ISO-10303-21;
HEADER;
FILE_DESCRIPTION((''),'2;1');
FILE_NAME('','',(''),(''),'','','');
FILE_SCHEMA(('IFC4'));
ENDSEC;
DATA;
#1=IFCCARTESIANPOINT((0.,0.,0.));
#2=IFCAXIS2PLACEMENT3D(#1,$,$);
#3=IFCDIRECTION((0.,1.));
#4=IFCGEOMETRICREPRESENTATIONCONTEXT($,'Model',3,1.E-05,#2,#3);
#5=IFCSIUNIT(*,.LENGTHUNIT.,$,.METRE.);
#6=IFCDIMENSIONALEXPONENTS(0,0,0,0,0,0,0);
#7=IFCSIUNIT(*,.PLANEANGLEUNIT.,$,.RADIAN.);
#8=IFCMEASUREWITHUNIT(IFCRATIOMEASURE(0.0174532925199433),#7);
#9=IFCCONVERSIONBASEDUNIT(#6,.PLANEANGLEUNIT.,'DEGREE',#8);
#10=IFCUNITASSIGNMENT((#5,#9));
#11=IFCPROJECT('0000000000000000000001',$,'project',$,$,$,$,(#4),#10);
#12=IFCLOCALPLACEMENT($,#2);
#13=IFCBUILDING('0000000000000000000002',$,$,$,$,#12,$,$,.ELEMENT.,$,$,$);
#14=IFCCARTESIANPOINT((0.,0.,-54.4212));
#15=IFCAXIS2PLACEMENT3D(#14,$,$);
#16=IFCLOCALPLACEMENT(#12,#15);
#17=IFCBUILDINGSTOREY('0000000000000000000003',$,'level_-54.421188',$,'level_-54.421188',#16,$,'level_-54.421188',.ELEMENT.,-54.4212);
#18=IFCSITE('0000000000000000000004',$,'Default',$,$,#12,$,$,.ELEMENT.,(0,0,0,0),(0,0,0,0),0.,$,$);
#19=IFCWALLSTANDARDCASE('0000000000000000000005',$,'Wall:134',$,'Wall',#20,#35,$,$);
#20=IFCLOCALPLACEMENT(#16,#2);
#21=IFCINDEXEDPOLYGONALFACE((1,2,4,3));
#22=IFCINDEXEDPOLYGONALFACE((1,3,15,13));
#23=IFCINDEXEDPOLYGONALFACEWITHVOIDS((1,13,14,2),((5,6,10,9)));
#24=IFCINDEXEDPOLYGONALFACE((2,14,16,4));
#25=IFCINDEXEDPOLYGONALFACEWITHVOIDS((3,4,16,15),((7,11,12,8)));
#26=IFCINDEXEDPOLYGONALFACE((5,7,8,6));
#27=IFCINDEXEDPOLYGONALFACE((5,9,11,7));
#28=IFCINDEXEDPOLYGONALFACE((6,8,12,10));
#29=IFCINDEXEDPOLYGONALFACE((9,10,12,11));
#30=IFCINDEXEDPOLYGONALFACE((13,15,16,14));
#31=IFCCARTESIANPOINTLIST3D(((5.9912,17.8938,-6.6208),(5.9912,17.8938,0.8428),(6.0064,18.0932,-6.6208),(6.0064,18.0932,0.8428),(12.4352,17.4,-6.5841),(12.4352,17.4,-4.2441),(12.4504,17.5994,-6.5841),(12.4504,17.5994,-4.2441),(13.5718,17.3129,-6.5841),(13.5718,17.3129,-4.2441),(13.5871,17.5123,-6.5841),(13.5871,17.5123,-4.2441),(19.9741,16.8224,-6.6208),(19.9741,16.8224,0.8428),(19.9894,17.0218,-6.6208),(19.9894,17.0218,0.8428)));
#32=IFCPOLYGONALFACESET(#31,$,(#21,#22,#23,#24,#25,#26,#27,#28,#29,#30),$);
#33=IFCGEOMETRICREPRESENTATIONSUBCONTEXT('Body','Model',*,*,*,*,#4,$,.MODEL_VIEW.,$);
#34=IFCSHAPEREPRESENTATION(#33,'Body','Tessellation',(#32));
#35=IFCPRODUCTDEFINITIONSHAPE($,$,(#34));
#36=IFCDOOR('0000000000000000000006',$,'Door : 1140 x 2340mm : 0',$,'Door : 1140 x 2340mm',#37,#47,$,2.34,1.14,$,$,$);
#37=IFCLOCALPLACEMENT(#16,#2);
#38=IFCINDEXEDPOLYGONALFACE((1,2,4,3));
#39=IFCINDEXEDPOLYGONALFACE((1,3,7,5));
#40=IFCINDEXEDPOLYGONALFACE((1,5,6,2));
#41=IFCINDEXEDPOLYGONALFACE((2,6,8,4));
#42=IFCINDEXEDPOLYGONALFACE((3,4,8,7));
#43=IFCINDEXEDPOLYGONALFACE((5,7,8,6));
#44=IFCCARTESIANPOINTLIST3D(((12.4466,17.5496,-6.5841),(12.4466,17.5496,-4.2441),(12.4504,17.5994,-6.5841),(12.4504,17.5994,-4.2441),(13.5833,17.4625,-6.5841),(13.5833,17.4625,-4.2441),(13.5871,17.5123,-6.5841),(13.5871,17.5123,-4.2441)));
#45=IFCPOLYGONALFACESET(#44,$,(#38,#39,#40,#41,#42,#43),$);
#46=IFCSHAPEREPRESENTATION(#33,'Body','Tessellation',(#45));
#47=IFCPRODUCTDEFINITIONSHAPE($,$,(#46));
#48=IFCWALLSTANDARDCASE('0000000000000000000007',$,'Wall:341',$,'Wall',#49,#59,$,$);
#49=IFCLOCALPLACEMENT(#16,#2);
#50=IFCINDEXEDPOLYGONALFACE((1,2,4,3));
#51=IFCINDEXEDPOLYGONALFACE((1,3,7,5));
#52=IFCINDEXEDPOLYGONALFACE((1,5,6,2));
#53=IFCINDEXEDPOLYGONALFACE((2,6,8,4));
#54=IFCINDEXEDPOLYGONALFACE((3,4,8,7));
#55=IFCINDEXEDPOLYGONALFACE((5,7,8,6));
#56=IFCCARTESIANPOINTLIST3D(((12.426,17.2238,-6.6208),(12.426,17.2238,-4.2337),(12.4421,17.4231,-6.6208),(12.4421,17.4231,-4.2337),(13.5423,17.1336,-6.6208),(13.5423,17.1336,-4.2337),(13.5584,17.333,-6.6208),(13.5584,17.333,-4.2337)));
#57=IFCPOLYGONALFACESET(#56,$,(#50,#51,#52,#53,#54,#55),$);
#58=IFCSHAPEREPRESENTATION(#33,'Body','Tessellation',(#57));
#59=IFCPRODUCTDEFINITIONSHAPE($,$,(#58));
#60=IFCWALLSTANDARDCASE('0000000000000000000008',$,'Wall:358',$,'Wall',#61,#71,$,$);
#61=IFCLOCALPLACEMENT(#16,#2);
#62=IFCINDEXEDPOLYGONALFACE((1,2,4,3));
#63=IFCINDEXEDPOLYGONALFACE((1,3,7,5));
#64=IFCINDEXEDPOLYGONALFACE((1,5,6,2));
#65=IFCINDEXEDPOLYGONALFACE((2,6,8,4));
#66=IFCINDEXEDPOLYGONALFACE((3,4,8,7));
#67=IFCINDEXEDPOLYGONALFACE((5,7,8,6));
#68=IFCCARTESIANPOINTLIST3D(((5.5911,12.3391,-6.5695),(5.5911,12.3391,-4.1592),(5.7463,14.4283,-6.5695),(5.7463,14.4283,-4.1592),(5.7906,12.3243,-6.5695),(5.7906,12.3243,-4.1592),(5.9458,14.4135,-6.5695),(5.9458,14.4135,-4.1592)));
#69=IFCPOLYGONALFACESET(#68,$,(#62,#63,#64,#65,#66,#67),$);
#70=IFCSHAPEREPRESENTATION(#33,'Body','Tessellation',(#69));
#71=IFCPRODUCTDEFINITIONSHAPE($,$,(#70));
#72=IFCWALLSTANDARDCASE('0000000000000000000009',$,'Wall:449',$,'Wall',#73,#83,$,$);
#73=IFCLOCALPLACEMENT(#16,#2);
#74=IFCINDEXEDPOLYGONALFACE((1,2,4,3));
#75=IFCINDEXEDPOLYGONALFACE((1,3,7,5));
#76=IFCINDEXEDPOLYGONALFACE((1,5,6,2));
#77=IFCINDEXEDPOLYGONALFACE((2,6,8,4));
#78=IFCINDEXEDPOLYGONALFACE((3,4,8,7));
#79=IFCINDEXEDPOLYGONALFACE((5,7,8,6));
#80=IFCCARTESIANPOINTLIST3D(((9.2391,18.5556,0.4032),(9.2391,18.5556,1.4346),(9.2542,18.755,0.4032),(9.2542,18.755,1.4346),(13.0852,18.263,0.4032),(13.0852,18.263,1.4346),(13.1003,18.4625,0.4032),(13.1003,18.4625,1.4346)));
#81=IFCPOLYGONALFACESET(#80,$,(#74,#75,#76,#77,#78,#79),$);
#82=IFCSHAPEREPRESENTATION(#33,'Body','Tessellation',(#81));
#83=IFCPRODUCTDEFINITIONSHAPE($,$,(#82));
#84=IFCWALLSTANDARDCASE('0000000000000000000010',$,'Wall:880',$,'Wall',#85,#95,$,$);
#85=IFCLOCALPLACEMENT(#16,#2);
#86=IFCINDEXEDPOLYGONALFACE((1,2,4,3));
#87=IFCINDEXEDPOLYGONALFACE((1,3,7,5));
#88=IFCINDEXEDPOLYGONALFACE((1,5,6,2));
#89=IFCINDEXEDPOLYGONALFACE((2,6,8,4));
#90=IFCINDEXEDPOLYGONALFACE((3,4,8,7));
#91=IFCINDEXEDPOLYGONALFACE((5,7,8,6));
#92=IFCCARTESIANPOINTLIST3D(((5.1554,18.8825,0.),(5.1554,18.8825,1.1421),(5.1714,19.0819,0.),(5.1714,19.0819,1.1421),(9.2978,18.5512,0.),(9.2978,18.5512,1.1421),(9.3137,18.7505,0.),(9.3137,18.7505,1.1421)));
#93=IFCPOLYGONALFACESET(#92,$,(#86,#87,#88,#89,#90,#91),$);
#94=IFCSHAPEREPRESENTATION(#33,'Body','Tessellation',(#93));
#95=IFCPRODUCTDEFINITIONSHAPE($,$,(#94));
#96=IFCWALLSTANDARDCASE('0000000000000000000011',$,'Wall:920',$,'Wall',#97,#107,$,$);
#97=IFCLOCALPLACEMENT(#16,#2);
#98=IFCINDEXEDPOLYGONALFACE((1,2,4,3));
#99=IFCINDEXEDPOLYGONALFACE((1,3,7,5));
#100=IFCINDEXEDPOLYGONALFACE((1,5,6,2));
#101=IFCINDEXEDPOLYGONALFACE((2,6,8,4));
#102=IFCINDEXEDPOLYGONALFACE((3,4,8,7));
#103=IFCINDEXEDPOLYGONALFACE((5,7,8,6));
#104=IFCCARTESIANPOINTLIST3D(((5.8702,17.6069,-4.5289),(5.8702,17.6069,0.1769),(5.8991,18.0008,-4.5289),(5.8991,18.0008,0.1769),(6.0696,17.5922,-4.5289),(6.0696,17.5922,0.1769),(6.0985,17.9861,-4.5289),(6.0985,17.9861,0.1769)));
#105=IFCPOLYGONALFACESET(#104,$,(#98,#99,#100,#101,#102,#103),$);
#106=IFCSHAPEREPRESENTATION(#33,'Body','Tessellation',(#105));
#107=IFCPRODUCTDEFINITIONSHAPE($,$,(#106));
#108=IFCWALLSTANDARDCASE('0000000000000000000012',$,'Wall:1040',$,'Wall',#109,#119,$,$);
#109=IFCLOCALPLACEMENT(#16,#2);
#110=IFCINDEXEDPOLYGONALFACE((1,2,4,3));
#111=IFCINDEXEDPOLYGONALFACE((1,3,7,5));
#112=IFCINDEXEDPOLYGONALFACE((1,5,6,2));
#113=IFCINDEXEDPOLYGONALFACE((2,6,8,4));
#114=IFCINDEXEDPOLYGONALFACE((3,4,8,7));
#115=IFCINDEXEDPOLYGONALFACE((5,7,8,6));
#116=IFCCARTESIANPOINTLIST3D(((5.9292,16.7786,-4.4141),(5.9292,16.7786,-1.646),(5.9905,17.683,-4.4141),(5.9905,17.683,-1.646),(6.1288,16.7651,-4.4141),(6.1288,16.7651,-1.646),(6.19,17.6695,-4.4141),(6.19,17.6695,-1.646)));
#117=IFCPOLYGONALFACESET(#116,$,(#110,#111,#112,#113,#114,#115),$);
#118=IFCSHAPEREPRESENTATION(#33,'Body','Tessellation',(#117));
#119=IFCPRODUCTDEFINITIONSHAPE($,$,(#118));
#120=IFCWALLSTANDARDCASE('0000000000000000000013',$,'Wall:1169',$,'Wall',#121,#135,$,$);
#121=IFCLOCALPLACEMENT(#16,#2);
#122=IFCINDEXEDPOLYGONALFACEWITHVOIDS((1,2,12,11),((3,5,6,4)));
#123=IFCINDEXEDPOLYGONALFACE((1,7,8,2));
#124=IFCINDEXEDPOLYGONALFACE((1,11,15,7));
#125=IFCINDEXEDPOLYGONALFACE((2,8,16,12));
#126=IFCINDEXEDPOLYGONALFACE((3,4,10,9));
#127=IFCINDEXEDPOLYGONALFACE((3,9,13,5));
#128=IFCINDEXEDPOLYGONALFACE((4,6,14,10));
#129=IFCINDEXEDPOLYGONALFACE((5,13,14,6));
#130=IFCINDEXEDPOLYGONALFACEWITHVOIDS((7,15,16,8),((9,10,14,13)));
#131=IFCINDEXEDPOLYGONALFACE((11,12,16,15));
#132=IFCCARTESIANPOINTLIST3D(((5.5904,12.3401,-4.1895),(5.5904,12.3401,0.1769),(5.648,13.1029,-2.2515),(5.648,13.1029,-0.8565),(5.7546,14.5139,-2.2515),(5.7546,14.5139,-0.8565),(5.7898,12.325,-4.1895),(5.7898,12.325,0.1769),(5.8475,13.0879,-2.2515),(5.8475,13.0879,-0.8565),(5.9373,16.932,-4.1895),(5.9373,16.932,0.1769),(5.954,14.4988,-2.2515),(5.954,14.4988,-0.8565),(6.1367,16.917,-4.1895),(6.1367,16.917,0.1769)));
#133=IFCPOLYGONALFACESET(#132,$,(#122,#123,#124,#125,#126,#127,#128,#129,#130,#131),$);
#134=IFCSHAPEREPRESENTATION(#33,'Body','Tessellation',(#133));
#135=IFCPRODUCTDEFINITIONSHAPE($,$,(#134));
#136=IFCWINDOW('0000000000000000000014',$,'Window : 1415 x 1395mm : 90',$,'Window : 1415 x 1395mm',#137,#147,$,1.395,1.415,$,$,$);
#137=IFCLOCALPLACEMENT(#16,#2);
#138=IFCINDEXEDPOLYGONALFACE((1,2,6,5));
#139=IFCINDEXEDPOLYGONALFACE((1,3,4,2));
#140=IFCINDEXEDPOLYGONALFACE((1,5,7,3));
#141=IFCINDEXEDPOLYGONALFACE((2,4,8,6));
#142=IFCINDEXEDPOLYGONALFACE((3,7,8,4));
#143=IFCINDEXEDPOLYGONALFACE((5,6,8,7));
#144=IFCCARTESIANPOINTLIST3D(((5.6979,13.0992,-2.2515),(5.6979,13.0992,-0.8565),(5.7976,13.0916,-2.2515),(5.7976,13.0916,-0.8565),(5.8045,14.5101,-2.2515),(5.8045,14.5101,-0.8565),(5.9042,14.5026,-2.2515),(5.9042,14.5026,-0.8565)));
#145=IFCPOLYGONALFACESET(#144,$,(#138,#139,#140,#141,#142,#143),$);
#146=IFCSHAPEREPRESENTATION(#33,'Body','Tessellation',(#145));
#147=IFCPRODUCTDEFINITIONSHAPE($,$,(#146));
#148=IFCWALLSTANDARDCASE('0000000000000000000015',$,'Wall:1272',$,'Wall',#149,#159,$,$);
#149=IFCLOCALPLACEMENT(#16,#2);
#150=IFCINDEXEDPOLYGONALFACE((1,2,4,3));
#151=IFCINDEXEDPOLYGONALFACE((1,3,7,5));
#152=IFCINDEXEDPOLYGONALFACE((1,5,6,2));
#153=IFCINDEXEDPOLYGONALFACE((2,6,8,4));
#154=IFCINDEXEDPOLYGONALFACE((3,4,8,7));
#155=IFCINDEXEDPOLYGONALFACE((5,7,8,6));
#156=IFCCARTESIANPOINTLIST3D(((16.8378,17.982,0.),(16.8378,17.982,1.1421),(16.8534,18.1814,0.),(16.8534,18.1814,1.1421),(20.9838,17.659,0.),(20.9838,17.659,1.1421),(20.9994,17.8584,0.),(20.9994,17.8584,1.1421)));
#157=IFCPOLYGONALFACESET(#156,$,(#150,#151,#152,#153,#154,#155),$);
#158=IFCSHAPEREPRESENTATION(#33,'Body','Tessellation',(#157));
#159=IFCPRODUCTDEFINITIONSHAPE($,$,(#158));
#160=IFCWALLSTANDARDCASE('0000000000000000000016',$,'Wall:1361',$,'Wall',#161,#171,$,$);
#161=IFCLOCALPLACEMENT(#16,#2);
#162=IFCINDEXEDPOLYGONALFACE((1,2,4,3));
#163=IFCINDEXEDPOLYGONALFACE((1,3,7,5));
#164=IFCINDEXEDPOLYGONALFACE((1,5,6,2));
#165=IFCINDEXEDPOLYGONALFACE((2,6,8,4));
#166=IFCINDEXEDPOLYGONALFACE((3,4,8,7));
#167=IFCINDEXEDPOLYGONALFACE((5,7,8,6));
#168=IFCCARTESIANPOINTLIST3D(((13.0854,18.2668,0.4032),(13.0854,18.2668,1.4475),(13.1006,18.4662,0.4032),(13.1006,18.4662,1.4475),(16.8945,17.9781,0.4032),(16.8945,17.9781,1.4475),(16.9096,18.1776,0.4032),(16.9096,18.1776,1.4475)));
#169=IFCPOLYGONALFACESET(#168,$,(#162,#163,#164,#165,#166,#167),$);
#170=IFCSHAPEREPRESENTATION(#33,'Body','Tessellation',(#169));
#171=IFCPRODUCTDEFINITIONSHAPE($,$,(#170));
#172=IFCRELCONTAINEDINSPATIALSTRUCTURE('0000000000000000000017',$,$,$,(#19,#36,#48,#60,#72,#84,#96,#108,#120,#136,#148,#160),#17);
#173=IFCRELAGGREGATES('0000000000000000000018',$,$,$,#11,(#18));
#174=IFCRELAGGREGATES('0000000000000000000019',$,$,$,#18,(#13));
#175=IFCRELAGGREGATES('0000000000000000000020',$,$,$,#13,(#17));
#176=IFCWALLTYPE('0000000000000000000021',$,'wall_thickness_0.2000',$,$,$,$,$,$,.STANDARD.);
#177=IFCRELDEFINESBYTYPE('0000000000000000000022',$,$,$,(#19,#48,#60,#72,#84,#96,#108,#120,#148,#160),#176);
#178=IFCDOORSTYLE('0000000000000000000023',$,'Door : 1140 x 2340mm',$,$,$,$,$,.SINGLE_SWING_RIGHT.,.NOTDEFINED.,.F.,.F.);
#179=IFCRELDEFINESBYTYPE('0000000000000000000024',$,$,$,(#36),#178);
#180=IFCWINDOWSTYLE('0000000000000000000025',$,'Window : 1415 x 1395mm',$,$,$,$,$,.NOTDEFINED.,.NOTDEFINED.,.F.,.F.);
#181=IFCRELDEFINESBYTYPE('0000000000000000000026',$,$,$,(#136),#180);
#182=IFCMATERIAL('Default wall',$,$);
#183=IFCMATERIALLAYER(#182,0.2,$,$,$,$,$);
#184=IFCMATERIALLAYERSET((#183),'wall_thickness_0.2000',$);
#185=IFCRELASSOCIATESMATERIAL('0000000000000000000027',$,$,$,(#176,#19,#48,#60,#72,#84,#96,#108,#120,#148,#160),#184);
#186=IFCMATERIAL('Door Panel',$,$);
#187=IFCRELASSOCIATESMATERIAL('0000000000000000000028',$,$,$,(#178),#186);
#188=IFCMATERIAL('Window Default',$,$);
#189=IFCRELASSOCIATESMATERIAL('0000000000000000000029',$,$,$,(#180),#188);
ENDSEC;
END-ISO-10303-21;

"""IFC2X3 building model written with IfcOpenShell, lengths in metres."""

from ifc_helpers import new_model, entity, si_unit, converted_unit, direction, frame, frame_2d, origin, origin_2d_with_axis, place, context, subcontext, project, spatial, polyline, rectangle, outline, extrude, source, transform, mapped, material, layer, layer_set, layer_usage, type_object, type_shapes, element, fill, save


model = new_model("IFC2X3")

# Units and contexts
model_context = context("Model", 3, precision=1e-05, world=origin(), true_north=direction((0.0, 1.0)))
body_context = subcontext(model_context, "Body", "Model", "MODEL_VIEW")
ifc_project = project(units=[si_unit("LENGTHUNIT", "METRE"), converted_unit("PLANEANGLEUNIT", "DEGREE", entity("IfcRatioMeasure", 0.0174532925199433), si_unit("PLANEANGLEUNIT", "RADIAN"), dimensions=[0, 0, 0, 0, 0, 0, 0])], contexts=[model_context])

# Site, building, storey
placement_1 = place(None, origin())
site = spatial("IfcSite", under=ifc_project, at=placement_1, Name="Default", CompositionType="ELEMENT", RefLatitude=(0, 0, 0, 0), RefLongitude=(0, 0, 0, 0), RefElevation=0.0)
building = spatial("IfcBuilding", under=site, at=placement_1, CompositionType="ELEMENT")
storey_placement = place(placement_1, frame((0.0, 0.0, -54.4212)))
storey = spatial("IfcBuildingStorey", under=building, at=storey_placement, Name="level_-54.421188", ObjectType="level_-54.421188", LongName="level_-54.421188", CompositionType="ELEMENT", Elevation=-54.4212)

# Wall, opening, door
ifc_material_1 = material(Name="Default wall")
ifc_layer = layer(ifc_material_1, 0.2)
ifc_layer_set = layer_set([ifc_layer], Name="wall_thickness_0.2000")
ifc_layer_usage = layer_usage(ifc_layer_set, "AXIS2", "POSITIVE", -0.1)
wall_type = type_object("IfcWallType", Name="wall_thickness_0.2000", PredefinedType="STANDARD", material=ifc_layer_set)
placement_2 = place(placement_1, frame((0.0, 0.0, -61.042)))
wall_1_placement = place(placement_2, frame((5.9988, 17.9935, 0.0), z_axis=(0.0, 0.0, 1.0), x_axis=(0.997077, -0.076397, 0.0)))
wall_1 = element("IfcWallStandardCase", 1, at=wall_1_placement, inside=storey, type_object=wall_type, material=ifc_layer_usage, Name="Wall:134", ObjectType="Wall", context=body_context, shape_type="SweptSolid", body=[
    extrude(outline(polyline([(14.0239, -0.1), (14.0239, 0.1), (0.0, 0.1), (0.0, -0.1), (14.0239, -0.1)])), origin(), (0.0, 0.0, 1.0), 7.4637),
])
opening_1_placement = place(wall_1_placement, frame((6.4629, -0.1, 0.0368)))
opening_1 = element("IfcOpeningElement", 2, at=opening_1_placement, cuts=wall_1, ObjectType="Opening", context=body_context, shape_type="SweptSolid", body=[
    extrude(rectangle(XDim=1.14, YDim=2.34, at=frame_2d((1.17, 0.57), x_axis=(0.0, 1.0))), frame((0.0, 0.0, 0.0), z_axis=(0.0, 1.0, 0.0), x_axis=(0.0, 0.0, 1.0)), (0.0, 0.0, 1.0), 0.2),
])
ifc_material_2 = material(Name="Door Panel")
door_style = type_object("IfcDoorStyle", Name="Door : 1140 x 2340mm", ConstructionType="NOTDEFINED", OperationType="SINGLE_SWING_RIGHT", ParameterTakesPrecedence=False, Sizeable=False, material=ifc_material_2)
shared_shape_1 = source(origin(), body_context, "Body", "SweptSolid", [
    extrude(rectangle(XDim=0.05, YDim=1.14, at=origin_2d_with_axis()), frame((0.57, 0.175, 0.0), z_axis=(0.0, 0.0, 1.0), x_axis=(0.0, 1.0, 0.0)), (0.0, 0.0, 1.0), 2.34),
])
type_shapes(door_style, [shared_shape_1])
door_placement = place(opening_1_placement, origin())
door = element("IfcDoor", 3, at=door_placement, inside=storey, type_object=door_style, Name="Door : 1140 x 2340mm : 0", ObjectType="Door : 1140 x 2340mm", OverallHeight=2.34, OverallWidth=1.14, context=body_context, shape_type="MappedRepresentation", body=[
    mapped(shared_shape_1, transform((0.0, 0.0, 0.0), scale=1.0)),
])
fill(opening_1, door)

# Walls
placement_3 = place(placement_1, frame((0.0, 0.0, -61.042)))
wall_2_placement = place(placement_3, frame((12.434, 17.3234, 0.0), z_axis=(0.0, 0.0, 1.0), x_axis=(0.996755, -0.080497, 0.0)))
element("IfcWallStandardCase", 4, at=wall_2_placement, inside=storey, type_object=wall_type, material=ifc_layer_usage, Name="Wall:341", ObjectType="Wall", context=body_context, shape_type="SweptSolid", body=[
    extrude(outline(polyline([(1.12, -0.1), (1.12, 0.1), (0.0, 0.1), (0.0, -0.1), (1.12, -0.1)])), origin(), (0.0, 0.0, 1.0), 2.3871),
])
placement_4 = place(placement_1, frame((0.0, 0.0, -60.9907)))
wall_3_placement = place(placement_4, frame((5.846, 14.4209, 0.0), z_axis=(0.0, 0.0, 1.0), x_axis=(-0.074075, -0.997253, 0.0)))
element("IfcWallStandardCase", 5, at=wall_3_placement, inside=storey, type_object=wall_type, material=ifc_layer_usage, Name="Wall:358", ObjectType="Wall", context=body_context, shape_type="SweptSolid", body=[
    extrude(outline(polyline([(2.095, -0.1), (2.095, 0.1), (0.0, 0.1), (0.0, -0.1), (2.095, -0.1)])), origin(), (0.0, 0.0, 1.0), 2.4102),
])
placement_5 = place(placement_1, frame((0.0, 0.0, -54.018)))
wall_4_placement = place(placement_5, frame((9.2466, 18.6553, 0.0), z_axis=(0.0, 0.0, 1.0), x_axis=(0.997119, -0.075853, 0.0)))
element("IfcWallStandardCase", 6, at=wall_4_placement, inside=storey, type_object=wall_type, material=ifc_layer_usage, Name="Wall:449", ObjectType="Wall", context=body_context, shape_type="SweptSolid", body=[
    extrude(outline(polyline([(3.8572, -0.1), (3.8572, 0.1), (0.0, 0.1), (0.0, -0.1), (3.8572, -0.1)])), origin(), (0.0, 0.0, 1.0), 1.0314),
])
wall_5_placement = place(storey_placement, frame((5.1634, 18.9822, 0.0), z_axis=(0.0, 0.0, 1.0), x_axis=(0.996816, -0.079732, 0.0)))
element("IfcWallStandardCase", 7, at=wall_5_placement, inside=storey, type_object=wall_type, material=ifc_layer_usage, Name="Wall:880", ObjectType="Wall", context=body_context, shape_type="SweptSolid", body=[
    extrude(outline(polyline([(4.1556, -0.1), (4.1556, 0.1), (0.0, 0.1), (0.0, -0.1), (4.1556, -0.1)])), origin(), (0.0, 0.0, 1.0), 1.1421),
])
placement_6 = place(placement_1, frame((0.0, 0.0, -58.9501)))
wall_6_placement = place(placement_6, frame((5.9988, 17.9935, 0.0), z_axis=(0.0, 0.0, 1.0), x_axis=(-0.073166, -0.99732, 0.0)))
element("IfcWallStandardCase", 8, at=wall_6_placement, inside=storey, type_object=wall_type, material=ifc_layer_usage, Name="Wall:920", ObjectType="Wall", context=body_context, shape_type="SweptSolid", body=[
    extrude(outline(polyline([(0.395, -0.1), (0.395, 0.1), (0.0, 0.1), (0.0, -0.1), (0.395, -0.1)])), origin(), (0.0, 0.0, 1.0), 4.7058),
])
placement_7 = place(placement_1, frame((0.0, 0.0, -58.8353)))
wall_7_placement = place(placement_7, frame((6.0903, 17.6763, 0.0), z_axis=(0.0, 0.0, 1.0), x_axis=(-0.067572, -0.997714, 0.0)))
element("IfcWallStandardCase", 9, at=wall_7_placement, inside=storey, type_object=wall_type, material=ifc_layer_usage, Name="Wall:1040", ObjectType="Wall", context=body_context, shape_type="SweptSolid", body=[
    extrude(outline(polyline([(0.9065, -0.1), (0.9065, 0.1), (0.0, 0.1), (0.0, -0.1), (0.9065, -0.1)])), origin(), (0.0, 0.0, 1.0), 2.7681),
])

# Wall, opening, window
placement_8 = place(placement_1, frame((0.0, 0.0, -58.6107)))
wall_8_placement = place(placement_8, frame((6.037, 16.9245, 0.0), z_axis=(0.0, 0.0, 1.0), x_axis=(-0.075321, -0.997159, 0.0)))
wall_8 = element("IfcWallStandardCase", 10, at=wall_8_placement, inside=storey, type_object=wall_type, material=ifc_layer_usage, Name="Wall:1169", ObjectType="Wall", context=body_context, shape_type="SweptSolid", body=[
    extrude(outline(polyline([(4.605, -0.1), (4.605, 0.1), (0.0, 0.1), (0.0, -0.1), (4.605, -0.1)])), origin(), (0.0, 0.0, 1.0), 4.3664),
])
opening_2_placement = place(wall_8_placement, frame((2.425, -0.1, 1.938)))
opening_2 = element("IfcOpeningElement", 11, at=opening_2_placement, cuts=wall_8, ObjectType="Opening", context=body_context, shape_type="SweptSolid", body=[
    extrude(rectangle(XDim=1.415, YDim=1.395, at=frame_2d((0.6975, 0.7075), x_axis=(0.0, 1.0))), frame((0.0, 0.0, 0.0), z_axis=(0.0, 1.0, 0.0), x_axis=(0.0, 0.0, 1.0)), (0.0, 0.0, 1.0), 0.2),
])
ifc_material_3 = material(Name="Window Default")
window_style = type_object("IfcWindowStyle", Name="Window : 1415 x 1395mm", ConstructionType="NOTDEFINED", OperationType="NOTDEFINED", ParameterTakesPrecedence=False, Sizeable=False, material=ifc_material_3)
shared_shape_2 = source(origin(), body_context, "Body", "SweptSolid", [
    extrude(rectangle(XDim=0.1, YDim=1.415, at=origin_2d_with_axis()), frame((0.7075, 0.1, 0.0), z_axis=(0.0, 0.0, 1.0), x_axis=(0.0, 1.0, 0.0)), (0.0, 0.0, 1.0), 1.395),
])
type_shapes(window_style, [shared_shape_2])
window_placement = place(opening_2_placement, origin())
window = element("IfcWindow", 12, at=window_placement, inside=storey, type_object=window_style, Name="Window : 1415 x 1395mm : 90", ObjectType="Window : 1415 x 1395mm", OverallHeight=1.395, OverallWidth=1.415, context=body_context, shape_type="MappedRepresentation", body=[
    mapped(shared_shape_2, transform((0.0, 0.0, 0.0), scale=1.0)),
])
fill(opening_2, window)

# Walls
wall_9_placement = place(storey_placement, frame((16.8456, 18.0817, 0.0), z_axis=(0.0, 0.0, 1.0), x_axis=(0.99698, -0.077663, 0.0)))
element("IfcWallStandardCase", 13, at=wall_9_placement, inside=storey, type_object=wall_type, material=ifc_layer_usage, Name="Wall:1272", ObjectType="Wall", context=body_context, shape_type="SweptSolid", body=[
    extrude(outline(polyline([(4.1586, -0.1), (4.1586, 0.1), (0.0, 0.1), (0.0, -0.1), (4.1586, -0.1)])), origin(), (0.0, 0.0, 1.0), 1.1421),
])
placement_9 = place(placement_1, frame((0.0, 0.0, -54.018)))
wall_10_placement = place(placement_9, frame((13.093, 18.3665, 0.0), z_axis=(0.0, 0.0, 1.0), x_axis=(0.997142, -0.075553, 0.0)))
element("IfcWallStandardCase", 14, at=wall_10_placement, inside=storey, type_object=wall_type, material=ifc_layer_usage, Name="Wall:1361", ObjectType="Wall", context=body_context, shape_type="SweptSolid", body=[
    extrude(outline(polyline([(3.82, -0.1), (3.82, 0.1), (0.0, 0.1), (0.0, -0.1), (3.82, -0.1)])), origin(), (0.0, 0.0, 1.0), 1.0443),
])

save(model, "model.ifc")
